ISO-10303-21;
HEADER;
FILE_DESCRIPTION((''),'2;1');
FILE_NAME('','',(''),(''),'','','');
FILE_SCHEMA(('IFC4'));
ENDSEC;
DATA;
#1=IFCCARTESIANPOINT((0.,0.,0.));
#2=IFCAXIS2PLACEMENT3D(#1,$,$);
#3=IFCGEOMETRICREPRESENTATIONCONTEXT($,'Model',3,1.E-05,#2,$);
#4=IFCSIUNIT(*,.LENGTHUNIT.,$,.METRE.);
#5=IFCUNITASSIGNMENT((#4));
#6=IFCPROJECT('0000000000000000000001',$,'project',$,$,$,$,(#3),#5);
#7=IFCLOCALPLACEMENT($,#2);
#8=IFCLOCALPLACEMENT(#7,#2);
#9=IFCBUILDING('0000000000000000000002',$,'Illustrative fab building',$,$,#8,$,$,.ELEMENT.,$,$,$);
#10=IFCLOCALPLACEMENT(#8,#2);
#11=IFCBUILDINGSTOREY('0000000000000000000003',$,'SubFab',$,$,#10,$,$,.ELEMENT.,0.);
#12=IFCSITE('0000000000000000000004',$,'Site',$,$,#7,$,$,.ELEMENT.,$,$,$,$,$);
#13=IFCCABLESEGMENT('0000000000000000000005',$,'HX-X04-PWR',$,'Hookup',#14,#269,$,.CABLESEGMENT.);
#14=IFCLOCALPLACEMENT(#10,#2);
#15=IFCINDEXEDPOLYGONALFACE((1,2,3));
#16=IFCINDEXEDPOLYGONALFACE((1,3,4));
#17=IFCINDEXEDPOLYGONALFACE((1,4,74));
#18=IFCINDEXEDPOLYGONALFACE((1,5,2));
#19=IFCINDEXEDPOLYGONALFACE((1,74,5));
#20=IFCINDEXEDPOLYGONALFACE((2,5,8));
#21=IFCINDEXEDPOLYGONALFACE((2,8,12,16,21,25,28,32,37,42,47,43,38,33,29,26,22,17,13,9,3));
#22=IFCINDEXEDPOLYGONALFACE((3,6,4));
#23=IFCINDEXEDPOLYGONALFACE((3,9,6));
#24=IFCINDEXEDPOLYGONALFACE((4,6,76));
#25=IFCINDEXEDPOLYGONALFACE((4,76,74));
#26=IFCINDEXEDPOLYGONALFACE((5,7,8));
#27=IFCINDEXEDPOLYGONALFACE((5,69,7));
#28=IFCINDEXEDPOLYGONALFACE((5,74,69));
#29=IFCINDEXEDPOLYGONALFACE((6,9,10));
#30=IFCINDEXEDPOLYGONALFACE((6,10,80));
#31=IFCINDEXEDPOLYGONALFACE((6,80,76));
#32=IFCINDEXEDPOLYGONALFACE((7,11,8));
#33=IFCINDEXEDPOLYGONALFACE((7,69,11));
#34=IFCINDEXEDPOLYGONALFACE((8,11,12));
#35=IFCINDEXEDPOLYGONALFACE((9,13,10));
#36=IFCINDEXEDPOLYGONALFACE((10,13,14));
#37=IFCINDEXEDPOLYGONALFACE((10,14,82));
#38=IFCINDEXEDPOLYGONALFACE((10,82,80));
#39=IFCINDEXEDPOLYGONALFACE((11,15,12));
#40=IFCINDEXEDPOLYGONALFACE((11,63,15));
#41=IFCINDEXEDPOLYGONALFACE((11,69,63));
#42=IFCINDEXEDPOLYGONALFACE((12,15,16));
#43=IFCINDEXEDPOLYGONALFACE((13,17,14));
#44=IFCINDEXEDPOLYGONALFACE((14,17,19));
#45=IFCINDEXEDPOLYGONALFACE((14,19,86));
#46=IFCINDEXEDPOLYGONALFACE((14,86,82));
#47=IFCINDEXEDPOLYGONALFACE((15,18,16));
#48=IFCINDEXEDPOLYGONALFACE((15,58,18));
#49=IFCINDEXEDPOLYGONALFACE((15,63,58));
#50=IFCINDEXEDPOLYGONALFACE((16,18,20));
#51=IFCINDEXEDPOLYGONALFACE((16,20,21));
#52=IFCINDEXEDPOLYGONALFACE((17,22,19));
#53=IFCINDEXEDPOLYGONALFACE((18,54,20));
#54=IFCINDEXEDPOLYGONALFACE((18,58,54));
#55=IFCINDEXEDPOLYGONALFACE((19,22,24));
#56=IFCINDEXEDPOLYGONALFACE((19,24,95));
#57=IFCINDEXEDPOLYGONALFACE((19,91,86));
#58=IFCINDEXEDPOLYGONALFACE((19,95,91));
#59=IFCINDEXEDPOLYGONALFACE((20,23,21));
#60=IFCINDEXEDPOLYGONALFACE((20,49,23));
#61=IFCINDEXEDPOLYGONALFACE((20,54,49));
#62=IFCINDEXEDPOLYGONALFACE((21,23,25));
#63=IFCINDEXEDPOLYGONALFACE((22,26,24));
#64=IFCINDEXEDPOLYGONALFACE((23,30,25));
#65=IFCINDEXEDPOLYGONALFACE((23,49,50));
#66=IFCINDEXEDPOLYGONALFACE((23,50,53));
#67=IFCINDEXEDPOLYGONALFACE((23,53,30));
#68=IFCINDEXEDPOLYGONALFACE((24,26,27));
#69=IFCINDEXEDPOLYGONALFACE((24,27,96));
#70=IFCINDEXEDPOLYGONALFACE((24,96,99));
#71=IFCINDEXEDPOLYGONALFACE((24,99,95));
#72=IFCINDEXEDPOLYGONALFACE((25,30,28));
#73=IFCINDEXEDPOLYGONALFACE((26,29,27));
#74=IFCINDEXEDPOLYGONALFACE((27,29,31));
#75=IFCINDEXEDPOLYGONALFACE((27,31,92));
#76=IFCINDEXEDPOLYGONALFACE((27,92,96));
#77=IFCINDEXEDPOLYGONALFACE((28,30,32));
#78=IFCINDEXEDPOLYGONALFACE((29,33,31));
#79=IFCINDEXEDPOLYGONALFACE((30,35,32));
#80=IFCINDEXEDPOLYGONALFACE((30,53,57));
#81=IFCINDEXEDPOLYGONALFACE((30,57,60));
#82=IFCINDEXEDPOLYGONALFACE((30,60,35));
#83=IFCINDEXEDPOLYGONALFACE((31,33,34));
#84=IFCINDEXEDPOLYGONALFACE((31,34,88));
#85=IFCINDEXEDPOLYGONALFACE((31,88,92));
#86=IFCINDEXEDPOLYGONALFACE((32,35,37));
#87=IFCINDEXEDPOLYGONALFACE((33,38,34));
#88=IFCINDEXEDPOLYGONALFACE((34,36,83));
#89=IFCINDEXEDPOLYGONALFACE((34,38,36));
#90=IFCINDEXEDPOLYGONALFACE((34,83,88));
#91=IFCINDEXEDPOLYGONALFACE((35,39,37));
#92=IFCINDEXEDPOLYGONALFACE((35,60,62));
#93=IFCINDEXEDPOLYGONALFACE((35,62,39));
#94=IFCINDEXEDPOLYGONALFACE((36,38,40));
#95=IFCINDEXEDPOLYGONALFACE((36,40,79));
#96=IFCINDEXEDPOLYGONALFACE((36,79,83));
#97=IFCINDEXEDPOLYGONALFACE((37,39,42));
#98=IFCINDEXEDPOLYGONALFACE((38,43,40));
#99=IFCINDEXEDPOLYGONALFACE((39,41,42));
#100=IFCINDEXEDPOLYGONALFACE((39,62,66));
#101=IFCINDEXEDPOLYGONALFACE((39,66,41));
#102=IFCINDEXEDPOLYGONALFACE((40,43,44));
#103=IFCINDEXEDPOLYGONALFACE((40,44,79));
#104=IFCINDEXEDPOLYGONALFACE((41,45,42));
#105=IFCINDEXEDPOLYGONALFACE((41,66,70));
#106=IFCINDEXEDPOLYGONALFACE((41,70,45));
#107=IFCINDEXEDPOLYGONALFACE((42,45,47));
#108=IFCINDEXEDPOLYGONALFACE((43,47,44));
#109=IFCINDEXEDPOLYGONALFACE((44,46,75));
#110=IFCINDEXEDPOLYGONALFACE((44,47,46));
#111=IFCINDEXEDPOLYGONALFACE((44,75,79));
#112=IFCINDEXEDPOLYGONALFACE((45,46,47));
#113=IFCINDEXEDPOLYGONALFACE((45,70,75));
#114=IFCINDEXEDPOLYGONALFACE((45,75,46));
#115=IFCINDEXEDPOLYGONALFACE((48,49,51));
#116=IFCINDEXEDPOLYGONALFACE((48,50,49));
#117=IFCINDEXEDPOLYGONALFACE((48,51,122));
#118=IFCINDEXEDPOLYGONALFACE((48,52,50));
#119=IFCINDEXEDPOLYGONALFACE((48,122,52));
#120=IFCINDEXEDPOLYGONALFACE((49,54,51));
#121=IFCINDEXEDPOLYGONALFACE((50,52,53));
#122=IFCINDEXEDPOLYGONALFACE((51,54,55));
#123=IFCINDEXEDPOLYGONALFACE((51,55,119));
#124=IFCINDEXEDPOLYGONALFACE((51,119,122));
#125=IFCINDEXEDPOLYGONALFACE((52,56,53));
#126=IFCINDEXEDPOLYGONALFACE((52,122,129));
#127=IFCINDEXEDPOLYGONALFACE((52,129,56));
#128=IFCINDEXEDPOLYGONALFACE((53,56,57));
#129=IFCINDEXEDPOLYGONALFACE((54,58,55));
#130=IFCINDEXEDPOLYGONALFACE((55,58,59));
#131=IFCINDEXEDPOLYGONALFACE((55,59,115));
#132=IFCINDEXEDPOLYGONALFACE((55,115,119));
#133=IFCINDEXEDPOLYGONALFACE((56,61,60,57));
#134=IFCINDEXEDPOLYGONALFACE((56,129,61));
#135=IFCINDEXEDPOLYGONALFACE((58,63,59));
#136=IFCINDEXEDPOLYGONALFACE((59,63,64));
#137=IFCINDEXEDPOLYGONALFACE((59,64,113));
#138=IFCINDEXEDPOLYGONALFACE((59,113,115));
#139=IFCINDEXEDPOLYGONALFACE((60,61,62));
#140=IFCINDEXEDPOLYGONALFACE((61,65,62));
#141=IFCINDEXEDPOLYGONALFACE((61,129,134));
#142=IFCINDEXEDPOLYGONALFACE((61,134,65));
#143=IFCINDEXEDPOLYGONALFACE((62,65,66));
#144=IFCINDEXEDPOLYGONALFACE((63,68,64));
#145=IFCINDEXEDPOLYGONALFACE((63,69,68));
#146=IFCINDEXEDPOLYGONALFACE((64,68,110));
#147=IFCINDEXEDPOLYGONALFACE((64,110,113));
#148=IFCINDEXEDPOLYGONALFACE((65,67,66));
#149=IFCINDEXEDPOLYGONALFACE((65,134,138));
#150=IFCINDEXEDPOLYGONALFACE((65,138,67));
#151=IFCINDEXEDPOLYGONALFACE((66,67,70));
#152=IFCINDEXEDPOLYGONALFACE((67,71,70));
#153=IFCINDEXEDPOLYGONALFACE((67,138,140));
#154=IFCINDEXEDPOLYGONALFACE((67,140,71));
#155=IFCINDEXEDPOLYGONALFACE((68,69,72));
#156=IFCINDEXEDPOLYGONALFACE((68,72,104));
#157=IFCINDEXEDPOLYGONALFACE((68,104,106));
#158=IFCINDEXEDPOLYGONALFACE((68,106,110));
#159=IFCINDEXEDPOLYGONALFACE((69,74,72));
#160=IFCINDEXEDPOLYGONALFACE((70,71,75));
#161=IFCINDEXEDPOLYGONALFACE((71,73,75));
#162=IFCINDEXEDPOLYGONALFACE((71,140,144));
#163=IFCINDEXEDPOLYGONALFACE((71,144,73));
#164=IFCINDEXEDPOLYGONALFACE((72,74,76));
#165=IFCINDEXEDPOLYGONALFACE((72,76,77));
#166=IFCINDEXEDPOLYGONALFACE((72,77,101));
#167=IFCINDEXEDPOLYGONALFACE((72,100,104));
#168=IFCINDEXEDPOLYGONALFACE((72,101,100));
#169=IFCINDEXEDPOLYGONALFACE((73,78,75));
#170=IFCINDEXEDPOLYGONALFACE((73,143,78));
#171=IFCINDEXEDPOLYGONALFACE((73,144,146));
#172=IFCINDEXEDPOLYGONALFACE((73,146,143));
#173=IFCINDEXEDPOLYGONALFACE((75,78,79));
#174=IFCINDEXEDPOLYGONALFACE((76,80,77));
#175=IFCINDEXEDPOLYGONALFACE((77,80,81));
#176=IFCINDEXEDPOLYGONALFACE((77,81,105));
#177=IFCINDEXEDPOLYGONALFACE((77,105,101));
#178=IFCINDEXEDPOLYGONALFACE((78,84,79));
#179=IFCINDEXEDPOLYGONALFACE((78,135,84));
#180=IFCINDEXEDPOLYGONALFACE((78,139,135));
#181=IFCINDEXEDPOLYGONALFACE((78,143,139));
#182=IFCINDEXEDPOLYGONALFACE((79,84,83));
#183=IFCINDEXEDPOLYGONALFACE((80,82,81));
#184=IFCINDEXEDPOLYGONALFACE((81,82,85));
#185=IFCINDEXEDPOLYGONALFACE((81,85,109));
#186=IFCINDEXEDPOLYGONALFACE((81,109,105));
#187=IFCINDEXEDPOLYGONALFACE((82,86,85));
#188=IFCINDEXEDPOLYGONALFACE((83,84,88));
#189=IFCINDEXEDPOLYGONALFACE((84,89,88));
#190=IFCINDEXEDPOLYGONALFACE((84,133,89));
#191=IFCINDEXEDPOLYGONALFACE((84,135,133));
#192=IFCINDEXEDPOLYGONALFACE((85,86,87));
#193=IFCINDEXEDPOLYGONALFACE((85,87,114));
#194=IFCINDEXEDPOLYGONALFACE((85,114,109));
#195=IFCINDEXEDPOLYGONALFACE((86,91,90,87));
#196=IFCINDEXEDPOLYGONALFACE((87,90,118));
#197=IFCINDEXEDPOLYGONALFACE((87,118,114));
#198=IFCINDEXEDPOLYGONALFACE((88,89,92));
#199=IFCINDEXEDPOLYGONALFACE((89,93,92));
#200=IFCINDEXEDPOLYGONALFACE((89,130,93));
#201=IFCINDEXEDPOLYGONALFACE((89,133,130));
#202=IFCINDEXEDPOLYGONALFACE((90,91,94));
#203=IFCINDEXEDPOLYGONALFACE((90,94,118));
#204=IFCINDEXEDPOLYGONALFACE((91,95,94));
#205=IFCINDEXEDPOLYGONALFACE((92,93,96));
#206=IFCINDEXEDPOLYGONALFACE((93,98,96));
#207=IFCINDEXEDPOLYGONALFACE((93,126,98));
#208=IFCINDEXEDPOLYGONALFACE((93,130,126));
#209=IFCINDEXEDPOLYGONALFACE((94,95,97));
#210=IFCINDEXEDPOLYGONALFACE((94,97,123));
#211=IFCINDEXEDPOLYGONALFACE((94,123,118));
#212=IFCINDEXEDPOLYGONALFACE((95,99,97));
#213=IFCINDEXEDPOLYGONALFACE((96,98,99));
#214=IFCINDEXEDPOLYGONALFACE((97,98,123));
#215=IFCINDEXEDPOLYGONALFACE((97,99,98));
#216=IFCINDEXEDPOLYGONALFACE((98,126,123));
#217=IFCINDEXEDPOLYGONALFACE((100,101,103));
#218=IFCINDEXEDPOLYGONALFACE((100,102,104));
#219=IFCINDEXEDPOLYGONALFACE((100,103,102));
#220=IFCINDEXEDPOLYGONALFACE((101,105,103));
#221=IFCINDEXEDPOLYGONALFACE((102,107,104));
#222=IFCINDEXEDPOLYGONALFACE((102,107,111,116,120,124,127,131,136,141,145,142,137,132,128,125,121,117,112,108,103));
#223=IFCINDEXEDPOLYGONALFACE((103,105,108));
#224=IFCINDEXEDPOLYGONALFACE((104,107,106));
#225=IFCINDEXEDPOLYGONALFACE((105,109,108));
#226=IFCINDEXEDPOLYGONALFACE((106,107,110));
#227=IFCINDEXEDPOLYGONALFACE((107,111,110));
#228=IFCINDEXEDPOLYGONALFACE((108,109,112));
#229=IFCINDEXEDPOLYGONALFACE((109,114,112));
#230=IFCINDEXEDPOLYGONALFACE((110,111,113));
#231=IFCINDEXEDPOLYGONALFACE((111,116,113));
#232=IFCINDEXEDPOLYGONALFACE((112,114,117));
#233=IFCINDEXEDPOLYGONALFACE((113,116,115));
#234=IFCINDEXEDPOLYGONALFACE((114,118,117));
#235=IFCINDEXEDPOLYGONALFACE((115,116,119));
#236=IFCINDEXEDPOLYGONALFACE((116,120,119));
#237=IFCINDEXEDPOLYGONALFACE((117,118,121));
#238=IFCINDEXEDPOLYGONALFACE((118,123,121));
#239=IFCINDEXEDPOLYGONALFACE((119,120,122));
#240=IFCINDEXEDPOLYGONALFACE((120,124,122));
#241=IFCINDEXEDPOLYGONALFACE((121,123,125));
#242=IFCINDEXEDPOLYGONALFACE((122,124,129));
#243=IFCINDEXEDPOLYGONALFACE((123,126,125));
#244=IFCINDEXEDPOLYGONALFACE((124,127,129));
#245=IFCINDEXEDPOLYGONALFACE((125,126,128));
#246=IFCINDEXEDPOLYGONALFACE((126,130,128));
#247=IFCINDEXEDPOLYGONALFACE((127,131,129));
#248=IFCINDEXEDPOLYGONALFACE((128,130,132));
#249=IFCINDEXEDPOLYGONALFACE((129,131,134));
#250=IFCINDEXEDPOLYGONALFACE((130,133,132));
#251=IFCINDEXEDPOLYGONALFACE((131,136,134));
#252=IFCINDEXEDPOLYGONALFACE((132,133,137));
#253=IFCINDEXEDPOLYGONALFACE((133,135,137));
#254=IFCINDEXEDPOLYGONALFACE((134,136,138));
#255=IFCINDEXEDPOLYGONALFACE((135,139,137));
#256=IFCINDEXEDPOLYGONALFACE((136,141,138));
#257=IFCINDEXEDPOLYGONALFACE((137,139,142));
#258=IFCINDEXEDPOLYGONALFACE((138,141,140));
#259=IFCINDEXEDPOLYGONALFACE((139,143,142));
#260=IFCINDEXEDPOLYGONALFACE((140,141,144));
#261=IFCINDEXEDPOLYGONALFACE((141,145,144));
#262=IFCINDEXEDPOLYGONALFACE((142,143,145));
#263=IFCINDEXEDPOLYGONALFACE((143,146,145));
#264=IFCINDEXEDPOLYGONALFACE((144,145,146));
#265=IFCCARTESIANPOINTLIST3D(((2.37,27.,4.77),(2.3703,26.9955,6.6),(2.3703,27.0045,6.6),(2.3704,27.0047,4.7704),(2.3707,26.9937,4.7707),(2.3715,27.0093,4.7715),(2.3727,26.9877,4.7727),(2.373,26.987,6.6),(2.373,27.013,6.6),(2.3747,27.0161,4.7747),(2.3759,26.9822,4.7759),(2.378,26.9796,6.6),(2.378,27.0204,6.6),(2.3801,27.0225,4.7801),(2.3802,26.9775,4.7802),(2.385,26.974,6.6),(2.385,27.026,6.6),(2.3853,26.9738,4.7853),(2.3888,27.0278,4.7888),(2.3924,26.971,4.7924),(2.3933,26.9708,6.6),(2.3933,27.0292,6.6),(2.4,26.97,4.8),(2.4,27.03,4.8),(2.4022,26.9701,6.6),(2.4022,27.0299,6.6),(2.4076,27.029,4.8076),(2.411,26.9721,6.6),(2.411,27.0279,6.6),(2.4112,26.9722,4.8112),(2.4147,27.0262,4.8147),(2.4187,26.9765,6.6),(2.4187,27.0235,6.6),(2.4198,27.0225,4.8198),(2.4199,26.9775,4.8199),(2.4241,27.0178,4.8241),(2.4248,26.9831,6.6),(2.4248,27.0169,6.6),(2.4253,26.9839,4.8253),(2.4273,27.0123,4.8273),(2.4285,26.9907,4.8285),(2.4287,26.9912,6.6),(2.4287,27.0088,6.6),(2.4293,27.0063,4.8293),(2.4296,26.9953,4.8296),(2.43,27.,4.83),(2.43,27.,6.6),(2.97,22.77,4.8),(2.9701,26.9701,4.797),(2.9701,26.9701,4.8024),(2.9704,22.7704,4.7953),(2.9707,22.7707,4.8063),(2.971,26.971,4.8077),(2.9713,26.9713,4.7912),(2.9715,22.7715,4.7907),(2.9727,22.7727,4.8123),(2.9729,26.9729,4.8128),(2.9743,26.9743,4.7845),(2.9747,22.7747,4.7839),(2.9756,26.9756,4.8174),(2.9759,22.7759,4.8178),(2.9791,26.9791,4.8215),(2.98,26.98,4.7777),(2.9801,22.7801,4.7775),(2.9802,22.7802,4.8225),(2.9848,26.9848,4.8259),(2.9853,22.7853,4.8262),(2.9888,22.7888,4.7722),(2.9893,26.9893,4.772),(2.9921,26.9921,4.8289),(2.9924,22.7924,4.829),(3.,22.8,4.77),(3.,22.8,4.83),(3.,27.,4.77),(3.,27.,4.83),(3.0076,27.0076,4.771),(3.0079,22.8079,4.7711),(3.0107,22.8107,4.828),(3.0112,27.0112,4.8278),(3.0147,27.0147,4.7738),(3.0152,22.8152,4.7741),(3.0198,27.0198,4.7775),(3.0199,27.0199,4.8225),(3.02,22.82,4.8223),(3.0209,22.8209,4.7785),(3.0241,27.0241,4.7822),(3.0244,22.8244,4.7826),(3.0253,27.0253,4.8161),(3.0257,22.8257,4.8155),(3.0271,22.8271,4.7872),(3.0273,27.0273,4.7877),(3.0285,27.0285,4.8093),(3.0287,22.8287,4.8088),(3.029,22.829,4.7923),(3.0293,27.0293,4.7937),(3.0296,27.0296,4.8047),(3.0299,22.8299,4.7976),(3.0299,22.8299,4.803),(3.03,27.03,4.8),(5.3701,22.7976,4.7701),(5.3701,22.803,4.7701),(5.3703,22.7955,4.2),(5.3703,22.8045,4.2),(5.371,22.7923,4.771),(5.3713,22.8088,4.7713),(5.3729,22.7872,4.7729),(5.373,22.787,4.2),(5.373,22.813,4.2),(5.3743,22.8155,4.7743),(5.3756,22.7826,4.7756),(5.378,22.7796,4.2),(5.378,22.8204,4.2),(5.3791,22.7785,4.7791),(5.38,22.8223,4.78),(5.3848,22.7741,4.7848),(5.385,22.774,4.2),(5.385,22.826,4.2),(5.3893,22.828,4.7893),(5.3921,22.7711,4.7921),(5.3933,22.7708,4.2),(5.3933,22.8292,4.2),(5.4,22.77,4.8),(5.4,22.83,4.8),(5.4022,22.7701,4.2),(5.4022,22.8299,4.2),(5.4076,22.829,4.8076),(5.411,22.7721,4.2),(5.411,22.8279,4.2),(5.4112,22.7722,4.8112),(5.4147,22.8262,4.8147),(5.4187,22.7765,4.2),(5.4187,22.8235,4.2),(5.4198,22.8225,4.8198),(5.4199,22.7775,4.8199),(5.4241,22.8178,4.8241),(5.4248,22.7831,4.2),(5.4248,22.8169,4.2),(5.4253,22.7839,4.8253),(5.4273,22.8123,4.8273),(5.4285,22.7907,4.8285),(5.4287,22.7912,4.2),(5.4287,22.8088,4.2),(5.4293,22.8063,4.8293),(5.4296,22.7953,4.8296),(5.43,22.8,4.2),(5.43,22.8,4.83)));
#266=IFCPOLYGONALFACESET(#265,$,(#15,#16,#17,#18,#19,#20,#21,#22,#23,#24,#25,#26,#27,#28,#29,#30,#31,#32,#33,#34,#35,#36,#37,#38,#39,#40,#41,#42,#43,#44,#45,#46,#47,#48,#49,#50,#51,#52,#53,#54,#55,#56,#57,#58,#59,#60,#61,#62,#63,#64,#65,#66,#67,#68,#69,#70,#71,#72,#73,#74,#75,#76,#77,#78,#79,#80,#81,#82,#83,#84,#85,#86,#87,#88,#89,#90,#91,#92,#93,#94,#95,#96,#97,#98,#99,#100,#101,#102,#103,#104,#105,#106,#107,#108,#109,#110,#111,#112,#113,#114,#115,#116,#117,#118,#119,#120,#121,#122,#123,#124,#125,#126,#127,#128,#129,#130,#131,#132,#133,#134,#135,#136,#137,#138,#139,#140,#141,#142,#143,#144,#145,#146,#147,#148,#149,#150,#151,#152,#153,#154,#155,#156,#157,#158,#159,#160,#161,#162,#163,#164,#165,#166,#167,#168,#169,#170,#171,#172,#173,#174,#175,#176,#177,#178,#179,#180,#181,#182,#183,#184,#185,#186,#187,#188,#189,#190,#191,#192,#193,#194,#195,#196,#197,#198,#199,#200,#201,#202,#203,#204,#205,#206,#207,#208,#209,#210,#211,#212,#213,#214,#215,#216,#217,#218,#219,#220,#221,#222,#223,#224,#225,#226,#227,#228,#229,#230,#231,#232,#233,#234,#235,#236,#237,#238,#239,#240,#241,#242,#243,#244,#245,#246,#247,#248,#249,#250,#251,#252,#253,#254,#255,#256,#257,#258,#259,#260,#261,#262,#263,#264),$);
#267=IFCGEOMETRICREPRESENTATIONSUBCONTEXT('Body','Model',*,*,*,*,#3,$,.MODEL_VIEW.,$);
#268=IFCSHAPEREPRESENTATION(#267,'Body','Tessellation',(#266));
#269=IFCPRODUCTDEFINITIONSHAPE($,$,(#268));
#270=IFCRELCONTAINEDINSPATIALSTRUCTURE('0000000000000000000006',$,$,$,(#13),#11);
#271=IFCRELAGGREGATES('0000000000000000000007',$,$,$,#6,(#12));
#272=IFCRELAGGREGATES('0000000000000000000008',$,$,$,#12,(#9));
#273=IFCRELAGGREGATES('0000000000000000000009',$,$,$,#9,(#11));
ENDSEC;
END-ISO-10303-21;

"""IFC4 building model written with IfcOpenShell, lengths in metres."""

from ifc_helpers import new_model, entity, si_unit, origin, place, context, subcontext, project, spatial, element, save


model = new_model("IFC4")

# Units and contexts
model_context = context("Model", 3, precision=1e-05, world=origin())
body_context = subcontext(model_context, "Body", "Model", "MODEL_VIEW")
ifc_project = project(units=[si_unit("LENGTHUNIT", "METRE")], contexts=[model_context])

# Site, building, storey
site_placement = place(None, origin())
site = spatial("IfcSite", under=ifc_project, at=site_placement, Name="Site", CompositionType="ELEMENT")
building_placement = place(site_placement, origin())
building = spatial("IfcBuilding", under=site, at=building_placement, Name="Illustrative fab building", CompositionType="ELEMENT")
storey_placement = place(building_placement, origin())
storey = spatial("IfcBuildingStorey", under=building, at=storey_placement, Name="SubFab", CompositionType="ELEMENT", Elevation=0.0)

# Cable segment
cable_segment_1_placement = place(storey_placement, origin())
element("IfcCableSegment", 1, at=cable_segment_1_placement, inside=storey, Name="HX-X04-PWR", ObjectType="Hookup", PredefinedType="CABLESEGMENT", context=body_context, shape_type="AdvancedSweptSolid", body=[
    entity("IfcSweptDiskSolid", entity("IfcPolyline", [entity("IfcCartesianPoint", [5.4, 22.8, 4.2]), entity("IfcCartesianPoint", [5.4, 22.8, 4.8]), entity("IfcCartesianPoint", [3.0, 22.8, 4.8]), entity("IfcCartesianPoint", [3.0, 27.0, 4.8]), entity("IfcCartesianPoint", [2.4, 27.0, 4.8]), entity("IfcCartesianPoint", [2.4, 27.0, 6.6])]), 0.03),
])

save(model, "model.ifc")
